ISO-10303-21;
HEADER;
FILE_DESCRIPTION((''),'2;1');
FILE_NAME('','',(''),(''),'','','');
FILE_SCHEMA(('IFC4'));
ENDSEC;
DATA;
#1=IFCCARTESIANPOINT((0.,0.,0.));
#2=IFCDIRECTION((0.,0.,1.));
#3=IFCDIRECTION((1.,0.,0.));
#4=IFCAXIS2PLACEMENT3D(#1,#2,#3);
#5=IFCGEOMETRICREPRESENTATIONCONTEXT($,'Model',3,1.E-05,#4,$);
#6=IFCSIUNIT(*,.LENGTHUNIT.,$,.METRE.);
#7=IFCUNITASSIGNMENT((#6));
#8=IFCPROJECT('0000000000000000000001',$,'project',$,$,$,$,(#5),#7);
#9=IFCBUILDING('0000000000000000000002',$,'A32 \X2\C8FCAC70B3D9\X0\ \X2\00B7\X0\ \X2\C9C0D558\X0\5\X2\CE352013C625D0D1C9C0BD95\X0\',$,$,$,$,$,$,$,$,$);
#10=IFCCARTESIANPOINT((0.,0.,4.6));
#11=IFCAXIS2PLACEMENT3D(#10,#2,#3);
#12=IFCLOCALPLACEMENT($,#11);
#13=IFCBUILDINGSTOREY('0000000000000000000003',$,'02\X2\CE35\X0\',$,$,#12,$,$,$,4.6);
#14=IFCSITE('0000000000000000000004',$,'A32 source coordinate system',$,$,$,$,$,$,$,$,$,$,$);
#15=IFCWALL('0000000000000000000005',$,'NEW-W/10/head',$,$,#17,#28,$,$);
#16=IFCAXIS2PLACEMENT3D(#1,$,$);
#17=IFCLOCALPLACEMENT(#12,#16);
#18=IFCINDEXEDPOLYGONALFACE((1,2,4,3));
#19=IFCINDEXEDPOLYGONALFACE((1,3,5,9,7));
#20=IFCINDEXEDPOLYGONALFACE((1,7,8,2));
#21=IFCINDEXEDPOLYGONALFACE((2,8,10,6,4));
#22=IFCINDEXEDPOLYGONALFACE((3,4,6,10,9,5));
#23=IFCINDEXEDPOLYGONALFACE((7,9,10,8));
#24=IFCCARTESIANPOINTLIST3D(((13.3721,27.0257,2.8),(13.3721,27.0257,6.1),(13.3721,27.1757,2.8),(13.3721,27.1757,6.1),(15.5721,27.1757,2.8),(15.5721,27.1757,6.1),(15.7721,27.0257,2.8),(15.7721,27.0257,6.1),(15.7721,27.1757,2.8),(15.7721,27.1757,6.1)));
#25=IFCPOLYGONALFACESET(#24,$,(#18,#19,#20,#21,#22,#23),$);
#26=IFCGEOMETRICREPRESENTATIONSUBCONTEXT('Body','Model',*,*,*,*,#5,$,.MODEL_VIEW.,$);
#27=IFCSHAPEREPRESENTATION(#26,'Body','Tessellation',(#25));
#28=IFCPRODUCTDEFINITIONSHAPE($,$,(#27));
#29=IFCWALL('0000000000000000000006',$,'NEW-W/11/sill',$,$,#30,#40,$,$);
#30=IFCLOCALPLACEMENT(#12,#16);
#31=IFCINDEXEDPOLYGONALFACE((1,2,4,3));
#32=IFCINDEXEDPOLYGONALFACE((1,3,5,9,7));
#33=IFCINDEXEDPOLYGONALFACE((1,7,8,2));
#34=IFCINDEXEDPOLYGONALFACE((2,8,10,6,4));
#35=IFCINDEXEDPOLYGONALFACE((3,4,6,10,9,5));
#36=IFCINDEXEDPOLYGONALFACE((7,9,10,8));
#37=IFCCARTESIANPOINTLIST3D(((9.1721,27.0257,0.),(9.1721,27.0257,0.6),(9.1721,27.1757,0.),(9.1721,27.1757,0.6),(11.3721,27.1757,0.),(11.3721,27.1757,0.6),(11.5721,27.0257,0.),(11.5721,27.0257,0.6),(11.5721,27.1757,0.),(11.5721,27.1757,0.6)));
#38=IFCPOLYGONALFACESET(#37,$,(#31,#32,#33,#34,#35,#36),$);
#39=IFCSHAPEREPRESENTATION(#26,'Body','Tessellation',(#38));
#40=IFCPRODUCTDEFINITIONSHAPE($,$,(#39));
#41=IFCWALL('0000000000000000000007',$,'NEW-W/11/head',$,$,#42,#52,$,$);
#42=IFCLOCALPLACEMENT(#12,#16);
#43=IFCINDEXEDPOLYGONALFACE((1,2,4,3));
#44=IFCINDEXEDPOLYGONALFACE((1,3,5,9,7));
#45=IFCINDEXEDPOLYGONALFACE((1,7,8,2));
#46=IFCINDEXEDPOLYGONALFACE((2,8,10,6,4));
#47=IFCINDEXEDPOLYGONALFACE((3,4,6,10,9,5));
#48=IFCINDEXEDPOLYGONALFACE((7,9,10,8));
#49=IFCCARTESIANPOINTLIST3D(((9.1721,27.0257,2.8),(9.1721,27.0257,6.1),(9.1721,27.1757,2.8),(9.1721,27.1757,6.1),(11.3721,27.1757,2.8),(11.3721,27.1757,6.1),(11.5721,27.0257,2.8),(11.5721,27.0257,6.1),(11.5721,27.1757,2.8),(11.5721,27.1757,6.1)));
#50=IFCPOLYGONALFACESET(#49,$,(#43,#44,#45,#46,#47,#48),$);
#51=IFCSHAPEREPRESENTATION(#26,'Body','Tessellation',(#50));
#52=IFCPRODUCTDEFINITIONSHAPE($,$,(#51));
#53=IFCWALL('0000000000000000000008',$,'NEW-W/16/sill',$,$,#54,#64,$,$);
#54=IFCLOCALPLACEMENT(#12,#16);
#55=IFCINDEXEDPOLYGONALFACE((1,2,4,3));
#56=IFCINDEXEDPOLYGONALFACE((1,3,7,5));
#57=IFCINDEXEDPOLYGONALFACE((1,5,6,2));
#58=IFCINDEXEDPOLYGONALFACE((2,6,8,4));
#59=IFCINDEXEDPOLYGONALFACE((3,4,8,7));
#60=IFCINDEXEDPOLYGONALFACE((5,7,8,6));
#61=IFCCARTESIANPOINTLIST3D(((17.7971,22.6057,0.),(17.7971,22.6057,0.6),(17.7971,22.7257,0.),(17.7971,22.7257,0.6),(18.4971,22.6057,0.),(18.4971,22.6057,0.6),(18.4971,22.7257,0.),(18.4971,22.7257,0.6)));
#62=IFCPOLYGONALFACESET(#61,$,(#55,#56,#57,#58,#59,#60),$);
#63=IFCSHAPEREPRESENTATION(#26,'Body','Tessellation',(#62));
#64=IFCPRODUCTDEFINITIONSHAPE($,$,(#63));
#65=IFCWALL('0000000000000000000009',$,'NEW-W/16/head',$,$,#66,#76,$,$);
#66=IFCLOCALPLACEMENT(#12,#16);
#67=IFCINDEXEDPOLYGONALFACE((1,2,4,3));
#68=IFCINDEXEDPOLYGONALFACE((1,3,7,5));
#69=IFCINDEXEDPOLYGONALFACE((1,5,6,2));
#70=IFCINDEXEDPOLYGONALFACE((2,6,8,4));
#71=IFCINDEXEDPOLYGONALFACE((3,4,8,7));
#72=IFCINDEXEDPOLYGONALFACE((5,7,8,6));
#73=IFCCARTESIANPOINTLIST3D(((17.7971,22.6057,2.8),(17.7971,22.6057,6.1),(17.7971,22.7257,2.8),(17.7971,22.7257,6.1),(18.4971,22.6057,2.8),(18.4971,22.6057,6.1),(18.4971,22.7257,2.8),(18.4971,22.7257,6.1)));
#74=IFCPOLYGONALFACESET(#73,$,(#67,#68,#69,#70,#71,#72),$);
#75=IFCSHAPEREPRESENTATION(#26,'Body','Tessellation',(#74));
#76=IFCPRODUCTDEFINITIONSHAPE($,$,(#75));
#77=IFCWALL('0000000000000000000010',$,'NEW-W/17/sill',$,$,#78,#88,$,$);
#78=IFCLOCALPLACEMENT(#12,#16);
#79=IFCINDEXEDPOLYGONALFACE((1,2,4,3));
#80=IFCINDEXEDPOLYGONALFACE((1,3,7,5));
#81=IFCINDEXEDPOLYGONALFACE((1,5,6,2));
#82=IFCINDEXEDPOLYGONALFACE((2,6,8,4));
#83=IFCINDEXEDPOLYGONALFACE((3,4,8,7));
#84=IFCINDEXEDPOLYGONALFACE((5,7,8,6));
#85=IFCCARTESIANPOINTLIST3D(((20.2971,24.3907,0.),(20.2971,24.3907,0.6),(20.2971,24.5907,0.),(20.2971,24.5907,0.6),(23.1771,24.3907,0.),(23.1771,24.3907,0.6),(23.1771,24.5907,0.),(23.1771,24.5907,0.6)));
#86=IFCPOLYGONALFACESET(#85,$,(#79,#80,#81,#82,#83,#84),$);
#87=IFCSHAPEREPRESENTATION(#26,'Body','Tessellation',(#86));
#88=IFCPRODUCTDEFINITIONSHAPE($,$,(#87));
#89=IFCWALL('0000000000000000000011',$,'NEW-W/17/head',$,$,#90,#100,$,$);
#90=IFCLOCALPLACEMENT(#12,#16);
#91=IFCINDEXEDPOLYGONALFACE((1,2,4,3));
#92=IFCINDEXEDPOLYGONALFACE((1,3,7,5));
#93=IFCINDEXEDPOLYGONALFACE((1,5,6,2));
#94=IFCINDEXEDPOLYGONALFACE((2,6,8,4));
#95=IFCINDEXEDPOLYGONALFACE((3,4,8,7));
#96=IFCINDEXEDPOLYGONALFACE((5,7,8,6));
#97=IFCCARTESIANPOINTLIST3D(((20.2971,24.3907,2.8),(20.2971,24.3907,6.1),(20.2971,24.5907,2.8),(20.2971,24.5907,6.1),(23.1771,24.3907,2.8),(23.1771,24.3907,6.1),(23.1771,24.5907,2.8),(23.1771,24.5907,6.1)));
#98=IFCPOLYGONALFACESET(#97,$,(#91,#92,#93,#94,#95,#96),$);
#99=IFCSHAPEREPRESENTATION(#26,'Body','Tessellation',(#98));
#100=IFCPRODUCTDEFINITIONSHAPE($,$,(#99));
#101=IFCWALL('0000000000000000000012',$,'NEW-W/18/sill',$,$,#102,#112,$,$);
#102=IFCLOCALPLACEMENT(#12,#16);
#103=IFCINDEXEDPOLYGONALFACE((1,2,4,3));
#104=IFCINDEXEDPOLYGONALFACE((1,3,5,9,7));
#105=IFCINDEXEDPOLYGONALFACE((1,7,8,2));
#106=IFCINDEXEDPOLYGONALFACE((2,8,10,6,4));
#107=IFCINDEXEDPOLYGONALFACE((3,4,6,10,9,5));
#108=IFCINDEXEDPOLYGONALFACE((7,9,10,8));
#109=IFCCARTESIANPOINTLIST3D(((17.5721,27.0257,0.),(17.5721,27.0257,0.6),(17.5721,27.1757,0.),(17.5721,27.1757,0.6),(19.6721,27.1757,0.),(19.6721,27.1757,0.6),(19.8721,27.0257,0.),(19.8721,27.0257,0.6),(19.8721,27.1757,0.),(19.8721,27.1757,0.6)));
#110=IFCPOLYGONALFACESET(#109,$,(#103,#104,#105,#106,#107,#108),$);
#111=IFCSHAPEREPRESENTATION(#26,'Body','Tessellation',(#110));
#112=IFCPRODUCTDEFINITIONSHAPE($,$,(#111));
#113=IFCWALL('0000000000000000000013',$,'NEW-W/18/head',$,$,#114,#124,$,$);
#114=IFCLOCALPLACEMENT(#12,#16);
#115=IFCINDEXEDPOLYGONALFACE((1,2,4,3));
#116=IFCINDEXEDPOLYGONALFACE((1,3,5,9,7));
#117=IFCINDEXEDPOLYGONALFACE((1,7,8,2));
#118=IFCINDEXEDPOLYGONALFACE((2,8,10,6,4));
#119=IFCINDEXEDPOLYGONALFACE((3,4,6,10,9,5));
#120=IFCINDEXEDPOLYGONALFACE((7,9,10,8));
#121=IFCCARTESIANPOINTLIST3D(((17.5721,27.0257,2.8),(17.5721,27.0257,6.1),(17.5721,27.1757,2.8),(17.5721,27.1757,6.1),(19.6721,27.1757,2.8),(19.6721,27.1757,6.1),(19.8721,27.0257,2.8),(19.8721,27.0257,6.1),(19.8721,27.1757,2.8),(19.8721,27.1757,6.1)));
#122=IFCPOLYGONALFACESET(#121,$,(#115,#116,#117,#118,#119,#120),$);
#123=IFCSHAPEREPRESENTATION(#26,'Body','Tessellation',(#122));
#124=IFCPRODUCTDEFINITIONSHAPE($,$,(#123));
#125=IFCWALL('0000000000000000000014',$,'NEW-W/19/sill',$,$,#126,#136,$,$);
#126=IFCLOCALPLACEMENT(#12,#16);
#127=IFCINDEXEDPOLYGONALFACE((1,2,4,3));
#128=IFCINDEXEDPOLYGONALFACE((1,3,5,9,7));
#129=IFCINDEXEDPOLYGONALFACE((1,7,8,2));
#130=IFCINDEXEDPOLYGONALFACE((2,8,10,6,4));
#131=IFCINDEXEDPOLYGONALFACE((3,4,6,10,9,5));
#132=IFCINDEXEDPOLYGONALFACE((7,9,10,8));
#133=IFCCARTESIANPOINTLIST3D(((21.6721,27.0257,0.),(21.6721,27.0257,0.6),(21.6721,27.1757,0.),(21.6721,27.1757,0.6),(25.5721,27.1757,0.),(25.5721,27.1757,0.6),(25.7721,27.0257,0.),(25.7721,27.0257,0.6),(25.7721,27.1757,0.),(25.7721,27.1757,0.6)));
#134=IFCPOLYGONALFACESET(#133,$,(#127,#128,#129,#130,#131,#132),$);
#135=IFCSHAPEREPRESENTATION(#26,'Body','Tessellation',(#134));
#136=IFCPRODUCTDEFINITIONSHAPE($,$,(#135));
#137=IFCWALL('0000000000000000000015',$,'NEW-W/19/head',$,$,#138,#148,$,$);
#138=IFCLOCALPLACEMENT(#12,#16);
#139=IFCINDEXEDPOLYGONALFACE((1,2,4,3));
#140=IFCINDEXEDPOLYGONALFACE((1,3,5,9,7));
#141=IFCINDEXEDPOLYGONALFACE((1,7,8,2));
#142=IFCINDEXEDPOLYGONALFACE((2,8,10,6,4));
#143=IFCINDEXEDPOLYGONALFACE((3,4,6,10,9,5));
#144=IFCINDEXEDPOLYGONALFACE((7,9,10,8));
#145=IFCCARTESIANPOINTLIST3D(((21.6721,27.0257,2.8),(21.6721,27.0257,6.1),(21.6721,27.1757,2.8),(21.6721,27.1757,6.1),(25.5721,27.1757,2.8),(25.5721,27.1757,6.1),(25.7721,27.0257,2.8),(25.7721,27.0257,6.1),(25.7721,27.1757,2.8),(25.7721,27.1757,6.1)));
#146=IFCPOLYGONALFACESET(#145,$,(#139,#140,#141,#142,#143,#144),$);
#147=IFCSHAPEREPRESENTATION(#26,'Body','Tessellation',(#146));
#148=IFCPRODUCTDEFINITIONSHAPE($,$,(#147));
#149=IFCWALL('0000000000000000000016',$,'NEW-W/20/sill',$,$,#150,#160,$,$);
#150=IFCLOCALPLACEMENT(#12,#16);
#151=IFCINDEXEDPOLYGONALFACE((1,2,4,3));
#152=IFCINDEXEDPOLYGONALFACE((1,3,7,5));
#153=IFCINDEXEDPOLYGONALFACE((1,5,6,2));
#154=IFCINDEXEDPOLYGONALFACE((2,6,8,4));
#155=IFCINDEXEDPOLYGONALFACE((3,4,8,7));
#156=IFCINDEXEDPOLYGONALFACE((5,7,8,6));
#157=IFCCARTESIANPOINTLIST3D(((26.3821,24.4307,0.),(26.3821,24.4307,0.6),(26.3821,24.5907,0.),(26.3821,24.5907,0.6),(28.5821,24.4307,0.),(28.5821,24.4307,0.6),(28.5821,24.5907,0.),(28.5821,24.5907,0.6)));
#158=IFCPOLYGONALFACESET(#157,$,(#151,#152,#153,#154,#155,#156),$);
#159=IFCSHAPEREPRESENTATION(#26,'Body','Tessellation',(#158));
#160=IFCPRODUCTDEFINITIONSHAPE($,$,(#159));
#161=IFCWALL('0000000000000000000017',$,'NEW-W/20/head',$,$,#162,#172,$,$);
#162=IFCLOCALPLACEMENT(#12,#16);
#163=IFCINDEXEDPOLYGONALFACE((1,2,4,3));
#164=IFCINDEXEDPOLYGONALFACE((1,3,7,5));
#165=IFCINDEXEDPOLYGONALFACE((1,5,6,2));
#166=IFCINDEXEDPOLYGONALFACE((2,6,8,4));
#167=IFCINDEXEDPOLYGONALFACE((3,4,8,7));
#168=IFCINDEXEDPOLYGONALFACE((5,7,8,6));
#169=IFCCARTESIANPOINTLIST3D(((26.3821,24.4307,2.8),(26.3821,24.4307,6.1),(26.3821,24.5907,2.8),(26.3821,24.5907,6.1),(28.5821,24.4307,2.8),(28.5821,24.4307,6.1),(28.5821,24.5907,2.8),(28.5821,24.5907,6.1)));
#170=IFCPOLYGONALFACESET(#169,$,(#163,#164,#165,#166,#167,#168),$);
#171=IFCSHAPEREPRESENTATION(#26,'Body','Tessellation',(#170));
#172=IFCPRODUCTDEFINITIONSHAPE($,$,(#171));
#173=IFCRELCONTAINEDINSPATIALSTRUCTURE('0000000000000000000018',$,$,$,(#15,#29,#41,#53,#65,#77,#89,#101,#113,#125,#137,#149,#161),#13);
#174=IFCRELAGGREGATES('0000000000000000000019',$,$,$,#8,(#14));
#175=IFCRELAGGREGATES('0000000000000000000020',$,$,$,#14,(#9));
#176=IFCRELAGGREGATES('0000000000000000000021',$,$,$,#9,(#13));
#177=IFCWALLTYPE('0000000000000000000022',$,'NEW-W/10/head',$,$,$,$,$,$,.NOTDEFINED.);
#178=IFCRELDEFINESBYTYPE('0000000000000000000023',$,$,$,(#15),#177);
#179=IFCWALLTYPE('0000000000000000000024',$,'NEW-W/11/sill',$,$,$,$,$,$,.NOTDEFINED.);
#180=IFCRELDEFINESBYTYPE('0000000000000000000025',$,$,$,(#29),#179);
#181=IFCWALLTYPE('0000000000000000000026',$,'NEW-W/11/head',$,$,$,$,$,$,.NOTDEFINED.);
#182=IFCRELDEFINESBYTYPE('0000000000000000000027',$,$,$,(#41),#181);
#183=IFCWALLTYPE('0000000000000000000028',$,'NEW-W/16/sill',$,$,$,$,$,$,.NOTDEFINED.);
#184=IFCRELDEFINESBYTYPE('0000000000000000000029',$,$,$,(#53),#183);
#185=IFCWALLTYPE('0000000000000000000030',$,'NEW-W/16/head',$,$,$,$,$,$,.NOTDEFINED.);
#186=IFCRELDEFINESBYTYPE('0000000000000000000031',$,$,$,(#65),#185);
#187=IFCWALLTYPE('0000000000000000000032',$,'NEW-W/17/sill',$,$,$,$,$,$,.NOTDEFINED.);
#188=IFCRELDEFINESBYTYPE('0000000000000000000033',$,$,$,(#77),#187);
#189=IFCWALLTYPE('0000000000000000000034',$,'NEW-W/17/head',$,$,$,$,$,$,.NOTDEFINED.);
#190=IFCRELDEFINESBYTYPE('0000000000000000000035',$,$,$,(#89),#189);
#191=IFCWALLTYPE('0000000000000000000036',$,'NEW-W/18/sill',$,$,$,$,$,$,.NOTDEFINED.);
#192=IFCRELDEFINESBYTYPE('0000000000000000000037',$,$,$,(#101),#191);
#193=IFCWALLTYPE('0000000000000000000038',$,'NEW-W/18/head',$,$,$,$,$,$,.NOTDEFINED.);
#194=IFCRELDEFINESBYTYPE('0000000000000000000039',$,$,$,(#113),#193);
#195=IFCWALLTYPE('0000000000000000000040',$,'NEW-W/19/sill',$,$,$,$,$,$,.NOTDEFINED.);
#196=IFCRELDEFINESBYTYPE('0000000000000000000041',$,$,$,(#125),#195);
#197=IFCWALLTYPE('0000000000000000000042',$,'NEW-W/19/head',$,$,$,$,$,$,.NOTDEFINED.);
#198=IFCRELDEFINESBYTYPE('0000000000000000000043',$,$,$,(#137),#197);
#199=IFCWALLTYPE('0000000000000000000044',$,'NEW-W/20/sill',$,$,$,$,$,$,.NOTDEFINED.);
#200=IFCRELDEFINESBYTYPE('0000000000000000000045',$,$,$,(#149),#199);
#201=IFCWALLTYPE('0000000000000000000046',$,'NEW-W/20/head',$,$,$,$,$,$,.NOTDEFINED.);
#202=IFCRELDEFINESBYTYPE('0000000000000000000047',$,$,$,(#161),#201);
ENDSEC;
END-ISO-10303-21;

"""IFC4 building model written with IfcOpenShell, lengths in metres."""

from ifc_helpers import new_model, si_unit, frame, origin, origin_with_axes, place, context, subcontext, project, spatial, polyline, outline, extrude, source, transform, mapped, type_object, type_shapes, element, save


model = new_model("IFC4")

# Units and contexts
model_context = context("Model", 3, precision=1e-05, world=origin_with_axes())
body_context = subcontext(model_context, "Body", "Model", "MODEL_VIEW")
ifc_project = project(units=[si_unit("LENGTHUNIT", "METRE")], contexts=[model_context])

# Site, building, storey
site = spatial("IfcSite", under=ifc_project, Name="A32 source coordinate system")
building = spatial("IfcBuilding", under=site, Name="A32 주거동 · 지하5층–옥탑지붕")
storey_placement = place(None, frame((0.0, 0.0, 4.6), z_axis=(0.0, 0.0, 1.0), x_axis=(1.0, 0.0, 0.0)))
storey = spatial("IfcBuildingStorey", under=building, at=storey_placement, Name="02층", Elevation=4.6)

# Walls
wall_type_1 = type_object("IfcWallType", Name="NEW-W/10/head", PredefinedType="NOTDEFINED")
shared_shape_1 = source(origin(), body_context, "Body", "SweptSolid", [
    extrude(outline(polyline([(15.7721, 27.0257), (13.3721, 27.0257), (13.3721, 27.1757), (15.5721, 27.1757), (15.5721, 27.1757), (15.7721, 27.1757), (15.7721, 27.0257)])), frame((0.0, 0.0, 2.8)), (0.0, 0.0, 1.0), 3.3),
])
type_shapes(wall_type_1, [shared_shape_1])
wall_1_placement = place(storey_placement, origin_with_axes())
element("IfcWall", 1, at=wall_1_placement, inside=storey, type_object=wall_type_1, Name="NEW-W/10/head", context=body_context, shape_type="MappedRepresentation", body=[
    mapped(shared_shape_1, transform((0.0, 0.0, 0.0), scale=1.0)),
])
wall_type_2 = type_object("IfcWallType", Name="NEW-W/11/sill", PredefinedType="NOTDEFINED")
shared_shape_2 = source(origin(), body_context, "Body", "SweptSolid", [
    extrude(outline(polyline([(11.5721, 27.0257), (9.1721, 27.0257), (9.1721, 27.1757), (11.3721, 27.1757), (11.3721, 27.1757), (11.5721, 27.1757), (11.5721, 27.0257)])), origin(), (0.0, 0.0, 1.0), 0.6),
])
type_shapes(wall_type_2, [shared_shape_2])
wall_2_placement = place(storey_placement, origin_with_axes())
element("IfcWall", 2, at=wall_2_placement, inside=storey, type_object=wall_type_2, Name="NEW-W/11/sill", context=body_context, shape_type="MappedRepresentation", body=[
    mapped(shared_shape_2, transform((0.0, 0.0, 0.0), scale=1.0)),
])
wall_type_3 = type_object("IfcWallType", Name="NEW-W/11/head", PredefinedType="NOTDEFINED")
shared_shape_3 = source(origin(), body_context, "Body", "SweptSolid", [
    extrude(outline(polyline([(11.5721, 27.0257), (9.1721, 27.0257), (9.1721, 27.1757), (11.3721, 27.1757), (11.3721, 27.1757), (11.5721, 27.1757), (11.5721, 27.0257)])), frame((0.0, 0.0, 2.8)), (0.0, 0.0, 1.0), 3.3),
])
type_shapes(wall_type_3, [shared_shape_3])
wall_3_placement = place(storey_placement, origin_with_axes())
element("IfcWall", 3, at=wall_3_placement, inside=storey, type_object=wall_type_3, Name="NEW-W/11/head", context=body_context, shape_type="MappedRepresentation", body=[
    mapped(shared_shape_3, transform((0.0, 0.0, 0.0), scale=1.0)),
])
wall_type_4 = type_object("IfcWallType", Name="NEW-W/16/sill", PredefinedType="NOTDEFINED")
shared_shape_4 = source(origin(), body_context, "Body", "SweptSolid", [
    extrude(outline(polyline([(17.7971, 22.6057), (17.7971, 22.7257), (18.4971, 22.7257), (18.4971, 22.6057), (17.7971, 22.6057)])), origin(), (0.0, 0.0, 1.0), 0.6),
])
type_shapes(wall_type_4, [shared_shape_4])
wall_4_placement = place(storey_placement, origin_with_axes())
element("IfcWall", 4, at=wall_4_placement, inside=storey, type_object=wall_type_4, Name="NEW-W/16/sill", context=body_context, shape_type="MappedRepresentation", body=[
    mapped(shared_shape_4, transform((0.0, 0.0, 0.0), scale=1.0)),
])
wall_type_5 = type_object("IfcWallType", Name="NEW-W/16/head", PredefinedType="NOTDEFINED")
shared_shape_5 = source(origin(), body_context, "Body", "SweptSolid", [
    extrude(outline(polyline([(17.7971, 22.6057), (17.7971, 22.7257), (18.4971, 22.7257), (18.4971, 22.6057), (17.7971, 22.6057)])), frame((0.0, 0.0, 2.8)), (0.0, 0.0, 1.0), 3.3),
])
type_shapes(wall_type_5, [shared_shape_5])
wall_5_placement = place(storey_placement, origin_with_axes())
element("IfcWall", 5, at=wall_5_placement, inside=storey, type_object=wall_type_5, Name="NEW-W/16/head", context=body_context, shape_type="MappedRepresentation", body=[
    mapped(shared_shape_5, transform((0.0, 0.0, 0.0), scale=1.0)),
])
wall_type_6 = type_object("IfcWallType", Name="NEW-W/17/sill", PredefinedType="NOTDEFINED")
shared_shape_6 = source(origin(), body_context, "Body", "SweptSolid", [
    extrude(outline(polyline([(20.2971, 24.3907), (20.2971, 24.5907), (23.1771, 24.5907), (23.1771, 24.3907), (20.2971, 24.3907)])), origin(), (0.0, 0.0, 1.0), 0.6),
])
type_shapes(wall_type_6, [shared_shape_6])
wall_6_placement = place(storey_placement, origin_with_axes())
element("IfcWall", 6, at=wall_6_placement, inside=storey, type_object=wall_type_6, Name="NEW-W/17/sill", context=body_context, shape_type="MappedRepresentation", body=[
    mapped(shared_shape_6, transform((0.0, 0.0, 0.0), scale=1.0)),
])
wall_type_7 = type_object("IfcWallType", Name="NEW-W/17/head", PredefinedType="NOTDEFINED")
shared_shape_7 = source(origin(), body_context, "Body", "SweptSolid", [
    extrude(outline(polyline([(20.2971, 24.3907), (20.2971, 24.5907), (23.1771, 24.5907), (23.1771, 24.3907), (20.2971, 24.3907)])), frame((0.0, 0.0, 2.8)), (0.0, 0.0, 1.0), 3.3),
])
type_shapes(wall_type_7, [shared_shape_7])
wall_7_placement = place(storey_placement, origin_with_axes())
element("IfcWall", 7, at=wall_7_placement, inside=storey, type_object=wall_type_7, Name="NEW-W/17/head", context=body_context, shape_type="MappedRepresentation", body=[
    mapped(shared_shape_7, transform((0.0, 0.0, 0.0), scale=1.0)),
])
wall_type_8 = type_object("IfcWallType", Name="NEW-W/18/sill", PredefinedType="NOTDEFINED")
shared_shape_8 = source(origin(), body_context, "Body", "SweptSolid", [
    extrude(outline(polyline([(19.8721, 27.0257), (17.5721, 27.0257), (17.5721, 27.1757), (19.6721, 27.1757), (19.6721, 27.1757), (19.8721, 27.1757), (19.8721, 27.0257)])), origin(), (0.0, 0.0, 1.0), 0.6),
])
type_shapes(wall_type_8, [shared_shape_8])
wall_8_placement = place(storey_placement, origin_with_axes())
element("IfcWall", 8, at=wall_8_placement, inside=storey, type_object=wall_type_8, Name="NEW-W/18/sill", context=body_context, shape_type="MappedRepresentation", body=[
    mapped(shared_shape_8, transform((0.0, 0.0, 0.0), scale=1.0)),
])
wall_type_9 = type_object("IfcWallType", Name="NEW-W/18/head", PredefinedType="NOTDEFINED")
shared_shape_9 = source(origin(), body_context, "Body", "SweptSolid", [
    extrude(outline(polyline([(19.8721, 27.0257), (17.5721, 27.0257), (17.5721, 27.1757), (19.6721, 27.1757), (19.6721, 27.1757), (19.8721, 27.1757), (19.8721, 27.0257)])), frame((0.0, 0.0, 2.8)), (0.0, 0.0, 1.0), 3.3),
])
type_shapes(wall_type_9, [shared_shape_9])
wall_9_placement = place(storey_placement, origin_with_axes())
element("IfcWall", 9, at=wall_9_placement, inside=storey, type_object=wall_type_9, Name="NEW-W/18/head", context=body_context, shape_type="MappedRepresentation", body=[
    mapped(shared_shape_9, transform((0.0, 0.0, 0.0), scale=1.0)),
])
wall_type_10 = type_object("IfcWallType", Name="NEW-W/19/sill", PredefinedType="NOTDEFINED")
shared_shape_10 = source(origin(), body_context, "Body", "SweptSolid", [
    extrude(outline(polyline([(25.7721, 27.0257), (21.6721, 27.0257), (21.6721, 27.1757), (25.5721, 27.1757), (25.5721, 27.1757), (25.7721, 27.1757), (25.7721, 27.0257)])), origin(), (0.0, 0.0, 1.0), 0.6),
])
type_shapes(wall_type_10, [shared_shape_10])
wall_10_placement = place(storey_placement, origin_with_axes())
element("IfcWall", 10, at=wall_10_placement, inside=storey, type_object=wall_type_10, Name="NEW-W/19/sill", context=body_context, shape_type="MappedRepresentation", body=[
    mapped(shared_shape_10, transform((0.0, 0.0, 0.0), scale=1.0)),
])
wall_type_11 = type_object("IfcWallType", Name="NEW-W/19/head", PredefinedType="NOTDEFINED")
shared_shape_11 = source(origin(), body_context, "Body", "SweptSolid", [
    extrude(outline(polyline([(25.7721, 27.0257), (21.6721, 27.0257), (21.6721, 27.1757), (25.5721, 27.1757), (25.5721, 27.1757), (25.7721, 27.1757), (25.7721, 27.0257)])), frame((0.0, 0.0, 2.8)), (0.0, 0.0, 1.0), 3.3),
])
type_shapes(wall_type_11, [shared_shape_11])
wall_11_placement = place(storey_placement, origin_with_axes())
element("IfcWall", 11, at=wall_11_placement, inside=storey, type_object=wall_type_11, Name="NEW-W/19/head", context=body_context, shape_type="MappedRepresentation", body=[
    mapped(shared_shape_11, transform((0.0, 0.0, 0.0), scale=1.0)),
])
wall_type_12 = type_object("IfcWallType", Name="NEW-W/20/sill", PredefinedType="NOTDEFINED")
shared_shape_12 = source(origin(), body_context, "Body", "SweptSolid", [
    extrude(outline(polyline([(26.3821, 24.4307), (26.3821, 24.5907), (28.5821, 24.5907), (28.5821, 24.4307), (26.3821, 24.4307)])), origin(), (0.0, 0.0, 1.0), 0.6),
])
type_shapes(wall_type_12, [shared_shape_12])
wall_12_placement = place(storey_placement, origin_with_axes())
element("IfcWall", 12, at=wall_12_placement, inside=storey, type_object=wall_type_12, Name="NEW-W/20/sill", context=body_context, shape_type="MappedRepresentation", body=[
    mapped(shared_shape_12, transform((0.0, 0.0, 0.0), scale=1.0)),
])
wall_type_13 = type_object("IfcWallType", Name="NEW-W/20/head", PredefinedType="NOTDEFINED")
shared_shape_13 = source(origin(), body_context, "Body", "SweptSolid", [
    extrude(outline(polyline([(26.3821, 24.4307), (26.3821, 24.5907), (28.5821, 24.5907), (28.5821, 24.4307), (26.3821, 24.4307)])), frame((0.0, 0.0, 2.8)), (0.0, 0.0, 1.0), 3.3),
])
type_shapes(wall_type_13, [shared_shape_13])
wall_13_placement = place(storey_placement, origin_with_axes())
element("IfcWall", 13, at=wall_13_placement, inside=storey, type_object=wall_type_13, Name="NEW-W/20/head", context=body_context, shape_type="MappedRepresentation", body=[
    mapped(shared_shape_13, transform((0.0, 0.0, 0.0), scale=1.0)),
])

save(model, "model.ifc")
